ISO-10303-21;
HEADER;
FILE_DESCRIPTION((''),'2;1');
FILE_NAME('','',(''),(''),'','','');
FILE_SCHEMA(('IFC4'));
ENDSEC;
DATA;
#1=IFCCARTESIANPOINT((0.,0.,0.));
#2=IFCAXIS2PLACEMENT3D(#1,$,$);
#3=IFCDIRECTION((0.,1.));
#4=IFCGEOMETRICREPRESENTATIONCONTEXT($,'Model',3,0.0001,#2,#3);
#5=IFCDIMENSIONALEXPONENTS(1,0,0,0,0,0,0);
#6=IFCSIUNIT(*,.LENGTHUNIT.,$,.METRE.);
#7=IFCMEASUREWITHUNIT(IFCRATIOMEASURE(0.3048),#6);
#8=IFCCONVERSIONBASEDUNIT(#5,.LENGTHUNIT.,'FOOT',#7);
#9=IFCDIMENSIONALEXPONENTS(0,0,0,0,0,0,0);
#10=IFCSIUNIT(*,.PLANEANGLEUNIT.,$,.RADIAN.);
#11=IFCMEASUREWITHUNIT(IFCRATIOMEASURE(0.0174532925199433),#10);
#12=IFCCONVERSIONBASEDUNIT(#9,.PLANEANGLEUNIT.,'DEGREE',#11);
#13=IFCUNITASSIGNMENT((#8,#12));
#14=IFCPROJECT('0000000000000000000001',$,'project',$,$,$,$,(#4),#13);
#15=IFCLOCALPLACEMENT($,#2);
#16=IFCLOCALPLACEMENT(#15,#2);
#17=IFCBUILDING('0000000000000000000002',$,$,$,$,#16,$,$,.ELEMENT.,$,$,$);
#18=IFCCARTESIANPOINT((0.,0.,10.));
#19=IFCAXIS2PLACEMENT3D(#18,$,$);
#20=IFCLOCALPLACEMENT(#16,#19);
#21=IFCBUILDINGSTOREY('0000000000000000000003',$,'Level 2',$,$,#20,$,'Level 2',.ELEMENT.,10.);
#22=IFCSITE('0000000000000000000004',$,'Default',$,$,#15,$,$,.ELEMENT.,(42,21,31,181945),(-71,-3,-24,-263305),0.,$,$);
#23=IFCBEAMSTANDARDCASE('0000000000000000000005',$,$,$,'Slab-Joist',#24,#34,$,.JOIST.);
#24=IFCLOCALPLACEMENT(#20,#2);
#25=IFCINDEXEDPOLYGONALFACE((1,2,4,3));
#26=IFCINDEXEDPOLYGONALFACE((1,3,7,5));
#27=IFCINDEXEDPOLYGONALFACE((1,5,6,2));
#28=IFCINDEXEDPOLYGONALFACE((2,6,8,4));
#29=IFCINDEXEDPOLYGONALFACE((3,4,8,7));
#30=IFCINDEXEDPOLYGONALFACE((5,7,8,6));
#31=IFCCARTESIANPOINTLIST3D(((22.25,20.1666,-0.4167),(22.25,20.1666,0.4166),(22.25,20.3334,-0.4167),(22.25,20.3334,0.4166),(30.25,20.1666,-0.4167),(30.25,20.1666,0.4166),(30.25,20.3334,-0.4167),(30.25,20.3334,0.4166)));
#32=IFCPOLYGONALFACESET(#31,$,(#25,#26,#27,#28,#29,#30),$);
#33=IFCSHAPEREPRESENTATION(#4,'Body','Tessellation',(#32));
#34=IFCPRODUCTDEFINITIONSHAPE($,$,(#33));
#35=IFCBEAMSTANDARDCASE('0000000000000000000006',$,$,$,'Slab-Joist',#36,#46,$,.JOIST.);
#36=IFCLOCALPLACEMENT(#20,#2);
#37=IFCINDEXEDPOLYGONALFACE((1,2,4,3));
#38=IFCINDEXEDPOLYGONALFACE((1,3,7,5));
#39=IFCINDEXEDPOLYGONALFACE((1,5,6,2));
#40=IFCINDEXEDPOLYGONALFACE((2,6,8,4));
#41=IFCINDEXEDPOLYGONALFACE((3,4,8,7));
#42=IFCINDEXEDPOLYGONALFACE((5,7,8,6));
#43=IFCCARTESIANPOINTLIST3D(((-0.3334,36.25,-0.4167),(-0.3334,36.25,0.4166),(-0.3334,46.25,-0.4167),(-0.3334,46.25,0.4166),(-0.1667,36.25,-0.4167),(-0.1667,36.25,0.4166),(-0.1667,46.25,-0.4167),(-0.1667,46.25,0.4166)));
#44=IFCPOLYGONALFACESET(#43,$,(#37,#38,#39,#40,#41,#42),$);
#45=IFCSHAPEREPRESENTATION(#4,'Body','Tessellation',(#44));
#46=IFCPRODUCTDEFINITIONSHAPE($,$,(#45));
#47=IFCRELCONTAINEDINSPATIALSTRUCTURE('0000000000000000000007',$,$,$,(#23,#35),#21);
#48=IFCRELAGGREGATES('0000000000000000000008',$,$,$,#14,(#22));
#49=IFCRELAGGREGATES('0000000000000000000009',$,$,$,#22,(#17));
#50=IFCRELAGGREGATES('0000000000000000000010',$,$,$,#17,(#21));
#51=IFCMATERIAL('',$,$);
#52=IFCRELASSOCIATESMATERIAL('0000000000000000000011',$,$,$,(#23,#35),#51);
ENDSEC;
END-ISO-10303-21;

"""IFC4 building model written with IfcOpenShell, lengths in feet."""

from ifc_helpers import new_model, entity, si_unit, converted_unit, direction, frame, origin, origin_with_axes, place, context, project, spatial, rectangle, extrude, material, element, save


model = new_model("IFC4")

# Units and contexts
model_context = context("Model", 3, precision=0.0001, world=origin(), true_north=direction((0.0, 1.0)))
ifc_project = project(units=[converted_unit("LENGTHUNIT", "FOOT", entity("IfcRatioMeasure", 0.3048), si_unit("LENGTHUNIT", "METRE"), dimensions=[1, 0, 0, 0, 0, 0, 0]), converted_unit("PLANEANGLEUNIT", "DEGREE", entity("IfcRatioMeasure", 0.0174532925199433), si_unit("PLANEANGLEUNIT", "RADIAN"), dimensions=[0, 0, 0, 0, 0, 0, 0])], contexts=[model_context])

# Site, building, storey
site_placement = place(None, origin())
site = spatial("IfcSite", under=ifc_project, at=site_placement, Name="Default", CompositionType="ELEMENT", RefLatitude=(42, 21, 31, 181945), RefLongitude=(-71, -3, -24, -263305), RefElevation=0.0)
building_placement = place(site_placement, origin())
building = spatial("IfcBuilding", under=site, at=building_placement, CompositionType="ELEMENT")
storey_placement = place(building_placement, frame((0.0, 0.0, 10.0)))
storey = spatial("IfcBuildingStorey", under=building, at=storey_placement, Name="Level 2", LongName="Level 2", CompositionType="ELEMENT", Elevation=10.0)

# Beams
ifc_material = material(Name="")
placement_1 = place(storey_placement, frame((22.25, 20.25, 0.0), z_axis=(0.0, 0.0, 1.0), x_axis=(1.0, 0.0, 0.0)))
beam_1_placement = place(placement_1, frame((0.0, 0.0, 0.0), z_axis=(1.0, 0.0, 0.0), x_axis=(0.0, 1.0, 0.0)))
element("IfcBeamStandardCase", 1, at=beam_1_placement, inside=storey, material=ifc_material, ObjectType="Slab-Joist", PredefinedType="JOIST", context=model_context, shape_type="SweptSolid", body=[
    extrude(rectangle(XDim=0.1667, YDim=0.8333), origin_with_axes(), (0.0, 0.0, 1.0), 8.0),
])
placement_2 = place(storey_placement, frame((-0.25, 36.25, 0.0), z_axis=(0.0, 0.0, 1.0), x_axis=(1.0, 0.0, 0.0)))
beam_2_placement = place(placement_2, frame((0.0, 0.0, 0.0), z_axis=(0.0, 1.0, 0.0), x_axis=(-1.0, 0.0, 0.0)))
element("IfcBeamStandardCase", 2, at=beam_2_placement, inside=storey, material=ifc_material, ObjectType="Slab-Joist", PredefinedType="JOIST", context=model_context, shape_type="SweptSolid", body=[
    extrude(rectangle(XDim=0.1667, YDim=0.8333), origin_with_axes(), (0.0, 0.0, 1.0), 10.0),
])

save(model, "model.ifc")
